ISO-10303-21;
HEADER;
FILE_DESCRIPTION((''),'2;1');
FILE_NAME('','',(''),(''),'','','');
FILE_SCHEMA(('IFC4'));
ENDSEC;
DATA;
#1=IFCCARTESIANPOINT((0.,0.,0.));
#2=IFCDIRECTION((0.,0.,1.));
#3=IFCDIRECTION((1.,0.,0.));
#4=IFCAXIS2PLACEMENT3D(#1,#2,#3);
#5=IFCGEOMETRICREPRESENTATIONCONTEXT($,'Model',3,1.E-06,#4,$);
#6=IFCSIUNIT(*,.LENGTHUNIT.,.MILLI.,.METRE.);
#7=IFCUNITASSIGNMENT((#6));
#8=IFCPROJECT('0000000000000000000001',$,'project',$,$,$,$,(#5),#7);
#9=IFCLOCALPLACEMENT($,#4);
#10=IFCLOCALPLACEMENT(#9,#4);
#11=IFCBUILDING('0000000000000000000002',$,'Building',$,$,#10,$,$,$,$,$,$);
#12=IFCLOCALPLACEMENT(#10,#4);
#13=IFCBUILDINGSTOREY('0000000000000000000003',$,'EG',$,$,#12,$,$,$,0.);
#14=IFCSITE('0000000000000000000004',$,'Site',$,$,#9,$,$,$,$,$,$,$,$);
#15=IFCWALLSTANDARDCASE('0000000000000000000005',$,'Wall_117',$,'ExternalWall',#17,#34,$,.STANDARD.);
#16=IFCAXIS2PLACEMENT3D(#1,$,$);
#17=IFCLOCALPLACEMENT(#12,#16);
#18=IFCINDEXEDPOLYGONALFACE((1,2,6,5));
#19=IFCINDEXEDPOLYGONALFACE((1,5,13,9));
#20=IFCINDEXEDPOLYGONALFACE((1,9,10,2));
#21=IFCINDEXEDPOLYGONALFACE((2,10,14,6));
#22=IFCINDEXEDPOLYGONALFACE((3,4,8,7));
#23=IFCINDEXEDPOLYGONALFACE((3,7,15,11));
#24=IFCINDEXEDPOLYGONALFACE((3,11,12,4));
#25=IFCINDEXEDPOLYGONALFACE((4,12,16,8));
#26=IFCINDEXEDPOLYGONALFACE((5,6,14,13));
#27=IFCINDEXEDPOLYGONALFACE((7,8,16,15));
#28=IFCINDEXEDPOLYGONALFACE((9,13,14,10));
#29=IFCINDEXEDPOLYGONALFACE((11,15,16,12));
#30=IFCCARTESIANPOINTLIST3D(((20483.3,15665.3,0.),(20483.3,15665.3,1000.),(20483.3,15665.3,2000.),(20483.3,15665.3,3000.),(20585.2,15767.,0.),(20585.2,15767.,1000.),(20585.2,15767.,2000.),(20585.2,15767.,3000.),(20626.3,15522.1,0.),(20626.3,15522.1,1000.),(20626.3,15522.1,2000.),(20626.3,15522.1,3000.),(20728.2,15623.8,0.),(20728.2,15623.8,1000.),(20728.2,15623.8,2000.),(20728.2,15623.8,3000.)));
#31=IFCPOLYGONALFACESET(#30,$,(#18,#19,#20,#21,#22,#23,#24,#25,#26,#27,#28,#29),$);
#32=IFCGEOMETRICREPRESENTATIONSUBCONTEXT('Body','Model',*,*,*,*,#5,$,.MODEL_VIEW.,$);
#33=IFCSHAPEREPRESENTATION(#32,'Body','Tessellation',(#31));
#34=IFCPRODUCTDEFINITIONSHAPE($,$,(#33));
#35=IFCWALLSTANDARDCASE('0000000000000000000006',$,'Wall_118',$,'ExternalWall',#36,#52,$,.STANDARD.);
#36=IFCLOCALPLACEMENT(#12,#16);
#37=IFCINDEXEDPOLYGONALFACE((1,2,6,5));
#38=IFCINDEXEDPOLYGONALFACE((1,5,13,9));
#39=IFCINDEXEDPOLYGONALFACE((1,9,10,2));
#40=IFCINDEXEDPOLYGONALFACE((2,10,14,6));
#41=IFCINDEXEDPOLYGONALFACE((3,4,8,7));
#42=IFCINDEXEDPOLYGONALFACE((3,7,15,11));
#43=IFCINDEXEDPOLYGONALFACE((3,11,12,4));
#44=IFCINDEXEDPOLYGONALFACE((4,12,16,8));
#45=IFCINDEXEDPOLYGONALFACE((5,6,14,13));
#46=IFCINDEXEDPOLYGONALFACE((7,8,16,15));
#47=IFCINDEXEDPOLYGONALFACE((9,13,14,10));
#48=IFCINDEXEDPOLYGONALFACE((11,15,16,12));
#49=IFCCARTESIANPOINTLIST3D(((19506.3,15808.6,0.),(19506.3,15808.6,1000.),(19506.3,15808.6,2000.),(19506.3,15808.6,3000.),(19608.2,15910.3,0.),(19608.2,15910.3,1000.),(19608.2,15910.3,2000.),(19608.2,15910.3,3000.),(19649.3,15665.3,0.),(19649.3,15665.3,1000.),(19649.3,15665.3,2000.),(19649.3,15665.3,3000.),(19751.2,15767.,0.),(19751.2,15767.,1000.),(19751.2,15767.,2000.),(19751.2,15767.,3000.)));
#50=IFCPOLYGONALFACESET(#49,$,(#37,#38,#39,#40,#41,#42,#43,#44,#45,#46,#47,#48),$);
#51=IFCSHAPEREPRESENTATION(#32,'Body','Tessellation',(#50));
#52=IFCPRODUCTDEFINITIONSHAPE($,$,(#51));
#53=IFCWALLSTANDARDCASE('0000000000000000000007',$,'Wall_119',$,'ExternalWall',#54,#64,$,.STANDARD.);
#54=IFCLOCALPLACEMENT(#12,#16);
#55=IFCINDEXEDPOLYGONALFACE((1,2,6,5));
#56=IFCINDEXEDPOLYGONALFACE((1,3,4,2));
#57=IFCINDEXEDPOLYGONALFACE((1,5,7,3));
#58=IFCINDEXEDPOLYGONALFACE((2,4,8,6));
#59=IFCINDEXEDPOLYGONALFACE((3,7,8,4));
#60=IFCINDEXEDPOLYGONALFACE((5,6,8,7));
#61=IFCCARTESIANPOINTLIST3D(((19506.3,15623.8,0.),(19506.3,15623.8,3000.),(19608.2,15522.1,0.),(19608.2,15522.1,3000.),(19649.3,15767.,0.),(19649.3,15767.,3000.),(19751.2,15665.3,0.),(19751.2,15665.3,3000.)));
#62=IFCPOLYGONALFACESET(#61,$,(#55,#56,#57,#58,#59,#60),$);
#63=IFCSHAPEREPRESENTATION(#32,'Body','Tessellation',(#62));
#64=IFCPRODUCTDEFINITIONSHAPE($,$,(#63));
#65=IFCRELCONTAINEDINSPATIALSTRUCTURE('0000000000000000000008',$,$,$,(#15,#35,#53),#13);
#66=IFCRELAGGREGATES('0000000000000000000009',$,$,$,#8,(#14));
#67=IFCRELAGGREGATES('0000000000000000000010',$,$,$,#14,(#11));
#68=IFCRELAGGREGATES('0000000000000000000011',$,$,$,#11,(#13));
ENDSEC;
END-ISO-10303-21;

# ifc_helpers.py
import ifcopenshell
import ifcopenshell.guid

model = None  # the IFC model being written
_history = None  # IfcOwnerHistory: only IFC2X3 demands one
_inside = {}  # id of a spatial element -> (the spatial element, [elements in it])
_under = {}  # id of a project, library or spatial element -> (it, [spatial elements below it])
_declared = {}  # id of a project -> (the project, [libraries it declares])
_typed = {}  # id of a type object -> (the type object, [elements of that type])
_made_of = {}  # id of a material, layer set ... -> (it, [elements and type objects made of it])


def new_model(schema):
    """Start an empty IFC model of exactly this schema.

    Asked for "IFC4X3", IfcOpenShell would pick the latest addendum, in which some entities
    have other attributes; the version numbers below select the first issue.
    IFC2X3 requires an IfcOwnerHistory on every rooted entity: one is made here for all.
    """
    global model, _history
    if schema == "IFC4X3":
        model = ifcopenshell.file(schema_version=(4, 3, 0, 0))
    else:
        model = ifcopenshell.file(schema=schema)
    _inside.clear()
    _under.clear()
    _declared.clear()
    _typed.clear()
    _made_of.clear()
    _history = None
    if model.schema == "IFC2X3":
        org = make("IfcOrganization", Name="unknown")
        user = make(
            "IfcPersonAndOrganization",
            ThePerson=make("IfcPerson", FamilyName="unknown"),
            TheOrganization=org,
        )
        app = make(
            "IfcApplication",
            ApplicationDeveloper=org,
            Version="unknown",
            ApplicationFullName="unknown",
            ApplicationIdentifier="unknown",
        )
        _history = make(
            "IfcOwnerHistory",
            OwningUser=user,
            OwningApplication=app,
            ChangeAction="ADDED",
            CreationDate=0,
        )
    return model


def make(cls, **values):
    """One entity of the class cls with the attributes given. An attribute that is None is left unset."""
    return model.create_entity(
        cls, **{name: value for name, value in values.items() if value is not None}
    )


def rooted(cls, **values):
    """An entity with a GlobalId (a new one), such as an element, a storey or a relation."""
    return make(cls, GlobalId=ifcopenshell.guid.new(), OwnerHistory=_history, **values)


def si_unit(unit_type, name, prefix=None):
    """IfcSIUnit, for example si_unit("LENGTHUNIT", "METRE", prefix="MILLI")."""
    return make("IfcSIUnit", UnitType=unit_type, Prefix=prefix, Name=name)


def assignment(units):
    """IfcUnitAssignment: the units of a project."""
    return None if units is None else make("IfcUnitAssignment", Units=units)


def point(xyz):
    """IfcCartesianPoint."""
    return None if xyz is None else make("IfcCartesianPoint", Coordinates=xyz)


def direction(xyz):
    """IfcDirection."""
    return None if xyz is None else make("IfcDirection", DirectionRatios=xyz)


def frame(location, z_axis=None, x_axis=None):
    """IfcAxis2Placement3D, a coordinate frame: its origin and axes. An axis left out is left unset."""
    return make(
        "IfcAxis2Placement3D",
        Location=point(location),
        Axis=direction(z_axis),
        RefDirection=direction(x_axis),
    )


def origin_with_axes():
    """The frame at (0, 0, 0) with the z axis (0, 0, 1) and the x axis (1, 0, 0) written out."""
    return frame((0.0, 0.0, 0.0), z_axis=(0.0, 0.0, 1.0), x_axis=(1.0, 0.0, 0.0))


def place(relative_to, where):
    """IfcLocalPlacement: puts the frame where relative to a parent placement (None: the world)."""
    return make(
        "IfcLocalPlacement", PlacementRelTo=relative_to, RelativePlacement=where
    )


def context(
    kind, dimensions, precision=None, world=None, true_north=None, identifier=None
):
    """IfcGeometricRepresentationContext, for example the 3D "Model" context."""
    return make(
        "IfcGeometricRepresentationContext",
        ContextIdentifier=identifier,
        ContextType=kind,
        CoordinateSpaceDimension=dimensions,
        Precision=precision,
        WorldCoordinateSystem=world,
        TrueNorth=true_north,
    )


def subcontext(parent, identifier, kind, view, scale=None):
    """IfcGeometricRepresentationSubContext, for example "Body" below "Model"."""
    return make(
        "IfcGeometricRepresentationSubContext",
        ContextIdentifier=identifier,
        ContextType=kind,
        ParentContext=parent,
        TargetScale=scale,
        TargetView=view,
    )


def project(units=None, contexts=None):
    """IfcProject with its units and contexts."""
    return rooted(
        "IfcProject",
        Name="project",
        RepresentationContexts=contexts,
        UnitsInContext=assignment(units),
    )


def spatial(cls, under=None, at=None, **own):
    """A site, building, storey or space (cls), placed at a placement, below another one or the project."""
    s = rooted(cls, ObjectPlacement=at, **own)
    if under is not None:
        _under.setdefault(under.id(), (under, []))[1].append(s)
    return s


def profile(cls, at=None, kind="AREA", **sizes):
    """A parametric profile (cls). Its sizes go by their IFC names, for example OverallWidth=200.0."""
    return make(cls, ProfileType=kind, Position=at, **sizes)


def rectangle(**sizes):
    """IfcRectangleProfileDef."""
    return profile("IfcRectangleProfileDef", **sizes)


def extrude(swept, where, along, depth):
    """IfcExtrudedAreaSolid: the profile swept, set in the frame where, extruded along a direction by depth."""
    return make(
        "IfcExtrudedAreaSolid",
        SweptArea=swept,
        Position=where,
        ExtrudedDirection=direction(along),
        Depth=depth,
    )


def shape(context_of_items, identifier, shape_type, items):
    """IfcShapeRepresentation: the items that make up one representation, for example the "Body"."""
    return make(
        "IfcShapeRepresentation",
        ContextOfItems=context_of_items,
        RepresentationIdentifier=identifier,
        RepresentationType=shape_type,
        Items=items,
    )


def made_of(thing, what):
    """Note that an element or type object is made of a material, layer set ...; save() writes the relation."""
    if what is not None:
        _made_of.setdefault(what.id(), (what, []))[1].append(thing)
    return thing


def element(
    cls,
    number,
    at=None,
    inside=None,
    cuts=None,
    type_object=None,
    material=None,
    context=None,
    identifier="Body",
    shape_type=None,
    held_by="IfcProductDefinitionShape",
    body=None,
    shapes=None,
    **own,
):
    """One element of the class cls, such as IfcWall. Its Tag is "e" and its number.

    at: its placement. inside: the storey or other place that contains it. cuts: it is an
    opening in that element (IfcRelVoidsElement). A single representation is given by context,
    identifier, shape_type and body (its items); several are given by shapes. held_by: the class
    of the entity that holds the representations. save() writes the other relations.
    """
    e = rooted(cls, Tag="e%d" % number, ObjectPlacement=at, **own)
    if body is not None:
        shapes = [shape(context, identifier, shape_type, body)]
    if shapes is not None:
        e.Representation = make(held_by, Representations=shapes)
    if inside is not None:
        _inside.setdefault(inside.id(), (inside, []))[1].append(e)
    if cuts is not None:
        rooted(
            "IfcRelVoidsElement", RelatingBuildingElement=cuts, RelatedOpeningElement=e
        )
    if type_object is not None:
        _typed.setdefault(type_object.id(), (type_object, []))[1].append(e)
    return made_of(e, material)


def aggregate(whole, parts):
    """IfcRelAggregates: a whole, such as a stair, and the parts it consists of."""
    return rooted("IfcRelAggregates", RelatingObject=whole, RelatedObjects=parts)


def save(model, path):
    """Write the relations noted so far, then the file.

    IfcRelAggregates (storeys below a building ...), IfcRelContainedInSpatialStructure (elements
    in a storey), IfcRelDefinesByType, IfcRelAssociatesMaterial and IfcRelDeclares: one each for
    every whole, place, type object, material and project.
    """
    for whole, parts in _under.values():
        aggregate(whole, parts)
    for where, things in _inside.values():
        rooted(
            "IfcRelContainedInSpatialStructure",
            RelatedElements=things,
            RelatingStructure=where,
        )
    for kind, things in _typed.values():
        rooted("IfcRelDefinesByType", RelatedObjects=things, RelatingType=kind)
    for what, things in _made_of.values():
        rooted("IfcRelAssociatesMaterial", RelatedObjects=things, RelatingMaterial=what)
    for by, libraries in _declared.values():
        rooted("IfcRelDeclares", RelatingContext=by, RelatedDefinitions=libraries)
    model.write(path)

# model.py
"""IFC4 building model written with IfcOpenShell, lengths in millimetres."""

from ifc_helpers import new_model, si_unit, frame, origin_with_axes, place, context, subcontext, project, spatial, rectangle, extrude, element, save


model = new_model("IFC4")

# Units and contexts
model_context = context("Model", 3, precision=1e-06, world=origin_with_axes())
body_context = subcontext(model_context, "Body", "Model", "MODEL_VIEW")
ifc_project = project(units=[si_unit("LENGTHUNIT", "METRE", prefix="MILLI")], contexts=[model_context])

# Site, building, storey
site_placement = place(None, origin_with_axes())
site = spatial("IfcSite", under=ifc_project, at=site_placement, Name="Site")
building_placement = place(site_placement, origin_with_axes())
building = spatial("IfcBuilding", under=site, at=building_placement, Name="Building")
storey_placement = place(building_placement, origin_with_axes())
storey = spatial("IfcBuildingStorey", under=building, at=storey_placement, Name="EG", Elevation=0.0)

# Walls, openings
wall_1_placement = place(storey_placement, origin_with_axes())
wall_1 = element("IfcWallStandardCase", 1, at=wall_1_placement, inside=storey, Name="Wall_117", ObjectType="ExternalWall", PredefinedType="STANDARD", context=body_context, shape_type="SweptSolid", body=[
    extrude(rectangle(XDim=202.4, YDim=144.0), frame((20605.8, 15644.5, 0.0), z_axis=(0.0, 0.0, 1.0), x_axis=(0.706489, -0.707724, 0.0)), (0.0, 0.0, 1.0), 3000.0),
])
opening_1_placement = place(wall_1_placement, origin_with_axes())
element("IfcOpeningElement", 2, at=opening_1_placement, inside=storey, cuts=wall_1, context=body_context, shape_type="SweptSolid", body=[
    extrude(rectangle(XDim=600.0, YDim=144.0), frame((20612.1, 15638.2, 1000.0), z_axis=(0.0, 0.0, 1.0), x_axis=(0.706489, -0.707724, 0.0)), (0.0, 0.0, 1.0), 1000.0),
])
wall_2_placement = place(storey_placement, origin_with_axes())
wall_2 = element("IfcWallStandardCase", 3, at=wall_2_placement, inside=storey, Name="Wall_118", ObjectType="ExternalWall", PredefinedType="STANDARD", context=body_context, shape_type="SweptSolid", body=[
    extrude(rectangle(XDim=202.4, YDim=144.0), frame((19628.8, 15787.8, 0.0), z_axis=(0.0, 0.0, 1.0), x_axis=(-0.706489, 0.707724, 0.0)), (0.0, 0.0, 1.0), 3000.0),
])
opening_2_placement = place(wall_2_placement, origin_with_axes())
element("IfcOpeningElement", 4, at=opening_2_placement, inside=storey, cuts=wall_2, context=body_context, shape_type="SweptSolid", body=[
    extrude(rectangle(XDim=600.0, YDim=144.0), frame((19622.4, 15794.2, 1000.0), z_axis=(0.0, 0.0, 1.0), x_axis=(-0.706489, 0.707724, 0.0)), (0.0, 0.0, 1.0), 1000.0),
])

# Wall
wall_3_placement = place(storey_placement, origin_with_axes())
element("IfcWallStandardCase", 5, at=wall_3_placement, inside=storey, Name="Wall_119", ObjectType="ExternalWall", PredefinedType="STANDARD", context=body_context, shape_type="SweptSolid", body=[
    extrude(rectangle(XDim=202.4, YDim=144.0), frame((19628.8, 15644.5, 0.0), z_axis=(0.0, 0.0, 1.0), x_axis=(-0.706489, -0.707724, 0.0)), (0.0, 0.0, 1.0), 3000.0),
])

save(model, "model.ifc")
